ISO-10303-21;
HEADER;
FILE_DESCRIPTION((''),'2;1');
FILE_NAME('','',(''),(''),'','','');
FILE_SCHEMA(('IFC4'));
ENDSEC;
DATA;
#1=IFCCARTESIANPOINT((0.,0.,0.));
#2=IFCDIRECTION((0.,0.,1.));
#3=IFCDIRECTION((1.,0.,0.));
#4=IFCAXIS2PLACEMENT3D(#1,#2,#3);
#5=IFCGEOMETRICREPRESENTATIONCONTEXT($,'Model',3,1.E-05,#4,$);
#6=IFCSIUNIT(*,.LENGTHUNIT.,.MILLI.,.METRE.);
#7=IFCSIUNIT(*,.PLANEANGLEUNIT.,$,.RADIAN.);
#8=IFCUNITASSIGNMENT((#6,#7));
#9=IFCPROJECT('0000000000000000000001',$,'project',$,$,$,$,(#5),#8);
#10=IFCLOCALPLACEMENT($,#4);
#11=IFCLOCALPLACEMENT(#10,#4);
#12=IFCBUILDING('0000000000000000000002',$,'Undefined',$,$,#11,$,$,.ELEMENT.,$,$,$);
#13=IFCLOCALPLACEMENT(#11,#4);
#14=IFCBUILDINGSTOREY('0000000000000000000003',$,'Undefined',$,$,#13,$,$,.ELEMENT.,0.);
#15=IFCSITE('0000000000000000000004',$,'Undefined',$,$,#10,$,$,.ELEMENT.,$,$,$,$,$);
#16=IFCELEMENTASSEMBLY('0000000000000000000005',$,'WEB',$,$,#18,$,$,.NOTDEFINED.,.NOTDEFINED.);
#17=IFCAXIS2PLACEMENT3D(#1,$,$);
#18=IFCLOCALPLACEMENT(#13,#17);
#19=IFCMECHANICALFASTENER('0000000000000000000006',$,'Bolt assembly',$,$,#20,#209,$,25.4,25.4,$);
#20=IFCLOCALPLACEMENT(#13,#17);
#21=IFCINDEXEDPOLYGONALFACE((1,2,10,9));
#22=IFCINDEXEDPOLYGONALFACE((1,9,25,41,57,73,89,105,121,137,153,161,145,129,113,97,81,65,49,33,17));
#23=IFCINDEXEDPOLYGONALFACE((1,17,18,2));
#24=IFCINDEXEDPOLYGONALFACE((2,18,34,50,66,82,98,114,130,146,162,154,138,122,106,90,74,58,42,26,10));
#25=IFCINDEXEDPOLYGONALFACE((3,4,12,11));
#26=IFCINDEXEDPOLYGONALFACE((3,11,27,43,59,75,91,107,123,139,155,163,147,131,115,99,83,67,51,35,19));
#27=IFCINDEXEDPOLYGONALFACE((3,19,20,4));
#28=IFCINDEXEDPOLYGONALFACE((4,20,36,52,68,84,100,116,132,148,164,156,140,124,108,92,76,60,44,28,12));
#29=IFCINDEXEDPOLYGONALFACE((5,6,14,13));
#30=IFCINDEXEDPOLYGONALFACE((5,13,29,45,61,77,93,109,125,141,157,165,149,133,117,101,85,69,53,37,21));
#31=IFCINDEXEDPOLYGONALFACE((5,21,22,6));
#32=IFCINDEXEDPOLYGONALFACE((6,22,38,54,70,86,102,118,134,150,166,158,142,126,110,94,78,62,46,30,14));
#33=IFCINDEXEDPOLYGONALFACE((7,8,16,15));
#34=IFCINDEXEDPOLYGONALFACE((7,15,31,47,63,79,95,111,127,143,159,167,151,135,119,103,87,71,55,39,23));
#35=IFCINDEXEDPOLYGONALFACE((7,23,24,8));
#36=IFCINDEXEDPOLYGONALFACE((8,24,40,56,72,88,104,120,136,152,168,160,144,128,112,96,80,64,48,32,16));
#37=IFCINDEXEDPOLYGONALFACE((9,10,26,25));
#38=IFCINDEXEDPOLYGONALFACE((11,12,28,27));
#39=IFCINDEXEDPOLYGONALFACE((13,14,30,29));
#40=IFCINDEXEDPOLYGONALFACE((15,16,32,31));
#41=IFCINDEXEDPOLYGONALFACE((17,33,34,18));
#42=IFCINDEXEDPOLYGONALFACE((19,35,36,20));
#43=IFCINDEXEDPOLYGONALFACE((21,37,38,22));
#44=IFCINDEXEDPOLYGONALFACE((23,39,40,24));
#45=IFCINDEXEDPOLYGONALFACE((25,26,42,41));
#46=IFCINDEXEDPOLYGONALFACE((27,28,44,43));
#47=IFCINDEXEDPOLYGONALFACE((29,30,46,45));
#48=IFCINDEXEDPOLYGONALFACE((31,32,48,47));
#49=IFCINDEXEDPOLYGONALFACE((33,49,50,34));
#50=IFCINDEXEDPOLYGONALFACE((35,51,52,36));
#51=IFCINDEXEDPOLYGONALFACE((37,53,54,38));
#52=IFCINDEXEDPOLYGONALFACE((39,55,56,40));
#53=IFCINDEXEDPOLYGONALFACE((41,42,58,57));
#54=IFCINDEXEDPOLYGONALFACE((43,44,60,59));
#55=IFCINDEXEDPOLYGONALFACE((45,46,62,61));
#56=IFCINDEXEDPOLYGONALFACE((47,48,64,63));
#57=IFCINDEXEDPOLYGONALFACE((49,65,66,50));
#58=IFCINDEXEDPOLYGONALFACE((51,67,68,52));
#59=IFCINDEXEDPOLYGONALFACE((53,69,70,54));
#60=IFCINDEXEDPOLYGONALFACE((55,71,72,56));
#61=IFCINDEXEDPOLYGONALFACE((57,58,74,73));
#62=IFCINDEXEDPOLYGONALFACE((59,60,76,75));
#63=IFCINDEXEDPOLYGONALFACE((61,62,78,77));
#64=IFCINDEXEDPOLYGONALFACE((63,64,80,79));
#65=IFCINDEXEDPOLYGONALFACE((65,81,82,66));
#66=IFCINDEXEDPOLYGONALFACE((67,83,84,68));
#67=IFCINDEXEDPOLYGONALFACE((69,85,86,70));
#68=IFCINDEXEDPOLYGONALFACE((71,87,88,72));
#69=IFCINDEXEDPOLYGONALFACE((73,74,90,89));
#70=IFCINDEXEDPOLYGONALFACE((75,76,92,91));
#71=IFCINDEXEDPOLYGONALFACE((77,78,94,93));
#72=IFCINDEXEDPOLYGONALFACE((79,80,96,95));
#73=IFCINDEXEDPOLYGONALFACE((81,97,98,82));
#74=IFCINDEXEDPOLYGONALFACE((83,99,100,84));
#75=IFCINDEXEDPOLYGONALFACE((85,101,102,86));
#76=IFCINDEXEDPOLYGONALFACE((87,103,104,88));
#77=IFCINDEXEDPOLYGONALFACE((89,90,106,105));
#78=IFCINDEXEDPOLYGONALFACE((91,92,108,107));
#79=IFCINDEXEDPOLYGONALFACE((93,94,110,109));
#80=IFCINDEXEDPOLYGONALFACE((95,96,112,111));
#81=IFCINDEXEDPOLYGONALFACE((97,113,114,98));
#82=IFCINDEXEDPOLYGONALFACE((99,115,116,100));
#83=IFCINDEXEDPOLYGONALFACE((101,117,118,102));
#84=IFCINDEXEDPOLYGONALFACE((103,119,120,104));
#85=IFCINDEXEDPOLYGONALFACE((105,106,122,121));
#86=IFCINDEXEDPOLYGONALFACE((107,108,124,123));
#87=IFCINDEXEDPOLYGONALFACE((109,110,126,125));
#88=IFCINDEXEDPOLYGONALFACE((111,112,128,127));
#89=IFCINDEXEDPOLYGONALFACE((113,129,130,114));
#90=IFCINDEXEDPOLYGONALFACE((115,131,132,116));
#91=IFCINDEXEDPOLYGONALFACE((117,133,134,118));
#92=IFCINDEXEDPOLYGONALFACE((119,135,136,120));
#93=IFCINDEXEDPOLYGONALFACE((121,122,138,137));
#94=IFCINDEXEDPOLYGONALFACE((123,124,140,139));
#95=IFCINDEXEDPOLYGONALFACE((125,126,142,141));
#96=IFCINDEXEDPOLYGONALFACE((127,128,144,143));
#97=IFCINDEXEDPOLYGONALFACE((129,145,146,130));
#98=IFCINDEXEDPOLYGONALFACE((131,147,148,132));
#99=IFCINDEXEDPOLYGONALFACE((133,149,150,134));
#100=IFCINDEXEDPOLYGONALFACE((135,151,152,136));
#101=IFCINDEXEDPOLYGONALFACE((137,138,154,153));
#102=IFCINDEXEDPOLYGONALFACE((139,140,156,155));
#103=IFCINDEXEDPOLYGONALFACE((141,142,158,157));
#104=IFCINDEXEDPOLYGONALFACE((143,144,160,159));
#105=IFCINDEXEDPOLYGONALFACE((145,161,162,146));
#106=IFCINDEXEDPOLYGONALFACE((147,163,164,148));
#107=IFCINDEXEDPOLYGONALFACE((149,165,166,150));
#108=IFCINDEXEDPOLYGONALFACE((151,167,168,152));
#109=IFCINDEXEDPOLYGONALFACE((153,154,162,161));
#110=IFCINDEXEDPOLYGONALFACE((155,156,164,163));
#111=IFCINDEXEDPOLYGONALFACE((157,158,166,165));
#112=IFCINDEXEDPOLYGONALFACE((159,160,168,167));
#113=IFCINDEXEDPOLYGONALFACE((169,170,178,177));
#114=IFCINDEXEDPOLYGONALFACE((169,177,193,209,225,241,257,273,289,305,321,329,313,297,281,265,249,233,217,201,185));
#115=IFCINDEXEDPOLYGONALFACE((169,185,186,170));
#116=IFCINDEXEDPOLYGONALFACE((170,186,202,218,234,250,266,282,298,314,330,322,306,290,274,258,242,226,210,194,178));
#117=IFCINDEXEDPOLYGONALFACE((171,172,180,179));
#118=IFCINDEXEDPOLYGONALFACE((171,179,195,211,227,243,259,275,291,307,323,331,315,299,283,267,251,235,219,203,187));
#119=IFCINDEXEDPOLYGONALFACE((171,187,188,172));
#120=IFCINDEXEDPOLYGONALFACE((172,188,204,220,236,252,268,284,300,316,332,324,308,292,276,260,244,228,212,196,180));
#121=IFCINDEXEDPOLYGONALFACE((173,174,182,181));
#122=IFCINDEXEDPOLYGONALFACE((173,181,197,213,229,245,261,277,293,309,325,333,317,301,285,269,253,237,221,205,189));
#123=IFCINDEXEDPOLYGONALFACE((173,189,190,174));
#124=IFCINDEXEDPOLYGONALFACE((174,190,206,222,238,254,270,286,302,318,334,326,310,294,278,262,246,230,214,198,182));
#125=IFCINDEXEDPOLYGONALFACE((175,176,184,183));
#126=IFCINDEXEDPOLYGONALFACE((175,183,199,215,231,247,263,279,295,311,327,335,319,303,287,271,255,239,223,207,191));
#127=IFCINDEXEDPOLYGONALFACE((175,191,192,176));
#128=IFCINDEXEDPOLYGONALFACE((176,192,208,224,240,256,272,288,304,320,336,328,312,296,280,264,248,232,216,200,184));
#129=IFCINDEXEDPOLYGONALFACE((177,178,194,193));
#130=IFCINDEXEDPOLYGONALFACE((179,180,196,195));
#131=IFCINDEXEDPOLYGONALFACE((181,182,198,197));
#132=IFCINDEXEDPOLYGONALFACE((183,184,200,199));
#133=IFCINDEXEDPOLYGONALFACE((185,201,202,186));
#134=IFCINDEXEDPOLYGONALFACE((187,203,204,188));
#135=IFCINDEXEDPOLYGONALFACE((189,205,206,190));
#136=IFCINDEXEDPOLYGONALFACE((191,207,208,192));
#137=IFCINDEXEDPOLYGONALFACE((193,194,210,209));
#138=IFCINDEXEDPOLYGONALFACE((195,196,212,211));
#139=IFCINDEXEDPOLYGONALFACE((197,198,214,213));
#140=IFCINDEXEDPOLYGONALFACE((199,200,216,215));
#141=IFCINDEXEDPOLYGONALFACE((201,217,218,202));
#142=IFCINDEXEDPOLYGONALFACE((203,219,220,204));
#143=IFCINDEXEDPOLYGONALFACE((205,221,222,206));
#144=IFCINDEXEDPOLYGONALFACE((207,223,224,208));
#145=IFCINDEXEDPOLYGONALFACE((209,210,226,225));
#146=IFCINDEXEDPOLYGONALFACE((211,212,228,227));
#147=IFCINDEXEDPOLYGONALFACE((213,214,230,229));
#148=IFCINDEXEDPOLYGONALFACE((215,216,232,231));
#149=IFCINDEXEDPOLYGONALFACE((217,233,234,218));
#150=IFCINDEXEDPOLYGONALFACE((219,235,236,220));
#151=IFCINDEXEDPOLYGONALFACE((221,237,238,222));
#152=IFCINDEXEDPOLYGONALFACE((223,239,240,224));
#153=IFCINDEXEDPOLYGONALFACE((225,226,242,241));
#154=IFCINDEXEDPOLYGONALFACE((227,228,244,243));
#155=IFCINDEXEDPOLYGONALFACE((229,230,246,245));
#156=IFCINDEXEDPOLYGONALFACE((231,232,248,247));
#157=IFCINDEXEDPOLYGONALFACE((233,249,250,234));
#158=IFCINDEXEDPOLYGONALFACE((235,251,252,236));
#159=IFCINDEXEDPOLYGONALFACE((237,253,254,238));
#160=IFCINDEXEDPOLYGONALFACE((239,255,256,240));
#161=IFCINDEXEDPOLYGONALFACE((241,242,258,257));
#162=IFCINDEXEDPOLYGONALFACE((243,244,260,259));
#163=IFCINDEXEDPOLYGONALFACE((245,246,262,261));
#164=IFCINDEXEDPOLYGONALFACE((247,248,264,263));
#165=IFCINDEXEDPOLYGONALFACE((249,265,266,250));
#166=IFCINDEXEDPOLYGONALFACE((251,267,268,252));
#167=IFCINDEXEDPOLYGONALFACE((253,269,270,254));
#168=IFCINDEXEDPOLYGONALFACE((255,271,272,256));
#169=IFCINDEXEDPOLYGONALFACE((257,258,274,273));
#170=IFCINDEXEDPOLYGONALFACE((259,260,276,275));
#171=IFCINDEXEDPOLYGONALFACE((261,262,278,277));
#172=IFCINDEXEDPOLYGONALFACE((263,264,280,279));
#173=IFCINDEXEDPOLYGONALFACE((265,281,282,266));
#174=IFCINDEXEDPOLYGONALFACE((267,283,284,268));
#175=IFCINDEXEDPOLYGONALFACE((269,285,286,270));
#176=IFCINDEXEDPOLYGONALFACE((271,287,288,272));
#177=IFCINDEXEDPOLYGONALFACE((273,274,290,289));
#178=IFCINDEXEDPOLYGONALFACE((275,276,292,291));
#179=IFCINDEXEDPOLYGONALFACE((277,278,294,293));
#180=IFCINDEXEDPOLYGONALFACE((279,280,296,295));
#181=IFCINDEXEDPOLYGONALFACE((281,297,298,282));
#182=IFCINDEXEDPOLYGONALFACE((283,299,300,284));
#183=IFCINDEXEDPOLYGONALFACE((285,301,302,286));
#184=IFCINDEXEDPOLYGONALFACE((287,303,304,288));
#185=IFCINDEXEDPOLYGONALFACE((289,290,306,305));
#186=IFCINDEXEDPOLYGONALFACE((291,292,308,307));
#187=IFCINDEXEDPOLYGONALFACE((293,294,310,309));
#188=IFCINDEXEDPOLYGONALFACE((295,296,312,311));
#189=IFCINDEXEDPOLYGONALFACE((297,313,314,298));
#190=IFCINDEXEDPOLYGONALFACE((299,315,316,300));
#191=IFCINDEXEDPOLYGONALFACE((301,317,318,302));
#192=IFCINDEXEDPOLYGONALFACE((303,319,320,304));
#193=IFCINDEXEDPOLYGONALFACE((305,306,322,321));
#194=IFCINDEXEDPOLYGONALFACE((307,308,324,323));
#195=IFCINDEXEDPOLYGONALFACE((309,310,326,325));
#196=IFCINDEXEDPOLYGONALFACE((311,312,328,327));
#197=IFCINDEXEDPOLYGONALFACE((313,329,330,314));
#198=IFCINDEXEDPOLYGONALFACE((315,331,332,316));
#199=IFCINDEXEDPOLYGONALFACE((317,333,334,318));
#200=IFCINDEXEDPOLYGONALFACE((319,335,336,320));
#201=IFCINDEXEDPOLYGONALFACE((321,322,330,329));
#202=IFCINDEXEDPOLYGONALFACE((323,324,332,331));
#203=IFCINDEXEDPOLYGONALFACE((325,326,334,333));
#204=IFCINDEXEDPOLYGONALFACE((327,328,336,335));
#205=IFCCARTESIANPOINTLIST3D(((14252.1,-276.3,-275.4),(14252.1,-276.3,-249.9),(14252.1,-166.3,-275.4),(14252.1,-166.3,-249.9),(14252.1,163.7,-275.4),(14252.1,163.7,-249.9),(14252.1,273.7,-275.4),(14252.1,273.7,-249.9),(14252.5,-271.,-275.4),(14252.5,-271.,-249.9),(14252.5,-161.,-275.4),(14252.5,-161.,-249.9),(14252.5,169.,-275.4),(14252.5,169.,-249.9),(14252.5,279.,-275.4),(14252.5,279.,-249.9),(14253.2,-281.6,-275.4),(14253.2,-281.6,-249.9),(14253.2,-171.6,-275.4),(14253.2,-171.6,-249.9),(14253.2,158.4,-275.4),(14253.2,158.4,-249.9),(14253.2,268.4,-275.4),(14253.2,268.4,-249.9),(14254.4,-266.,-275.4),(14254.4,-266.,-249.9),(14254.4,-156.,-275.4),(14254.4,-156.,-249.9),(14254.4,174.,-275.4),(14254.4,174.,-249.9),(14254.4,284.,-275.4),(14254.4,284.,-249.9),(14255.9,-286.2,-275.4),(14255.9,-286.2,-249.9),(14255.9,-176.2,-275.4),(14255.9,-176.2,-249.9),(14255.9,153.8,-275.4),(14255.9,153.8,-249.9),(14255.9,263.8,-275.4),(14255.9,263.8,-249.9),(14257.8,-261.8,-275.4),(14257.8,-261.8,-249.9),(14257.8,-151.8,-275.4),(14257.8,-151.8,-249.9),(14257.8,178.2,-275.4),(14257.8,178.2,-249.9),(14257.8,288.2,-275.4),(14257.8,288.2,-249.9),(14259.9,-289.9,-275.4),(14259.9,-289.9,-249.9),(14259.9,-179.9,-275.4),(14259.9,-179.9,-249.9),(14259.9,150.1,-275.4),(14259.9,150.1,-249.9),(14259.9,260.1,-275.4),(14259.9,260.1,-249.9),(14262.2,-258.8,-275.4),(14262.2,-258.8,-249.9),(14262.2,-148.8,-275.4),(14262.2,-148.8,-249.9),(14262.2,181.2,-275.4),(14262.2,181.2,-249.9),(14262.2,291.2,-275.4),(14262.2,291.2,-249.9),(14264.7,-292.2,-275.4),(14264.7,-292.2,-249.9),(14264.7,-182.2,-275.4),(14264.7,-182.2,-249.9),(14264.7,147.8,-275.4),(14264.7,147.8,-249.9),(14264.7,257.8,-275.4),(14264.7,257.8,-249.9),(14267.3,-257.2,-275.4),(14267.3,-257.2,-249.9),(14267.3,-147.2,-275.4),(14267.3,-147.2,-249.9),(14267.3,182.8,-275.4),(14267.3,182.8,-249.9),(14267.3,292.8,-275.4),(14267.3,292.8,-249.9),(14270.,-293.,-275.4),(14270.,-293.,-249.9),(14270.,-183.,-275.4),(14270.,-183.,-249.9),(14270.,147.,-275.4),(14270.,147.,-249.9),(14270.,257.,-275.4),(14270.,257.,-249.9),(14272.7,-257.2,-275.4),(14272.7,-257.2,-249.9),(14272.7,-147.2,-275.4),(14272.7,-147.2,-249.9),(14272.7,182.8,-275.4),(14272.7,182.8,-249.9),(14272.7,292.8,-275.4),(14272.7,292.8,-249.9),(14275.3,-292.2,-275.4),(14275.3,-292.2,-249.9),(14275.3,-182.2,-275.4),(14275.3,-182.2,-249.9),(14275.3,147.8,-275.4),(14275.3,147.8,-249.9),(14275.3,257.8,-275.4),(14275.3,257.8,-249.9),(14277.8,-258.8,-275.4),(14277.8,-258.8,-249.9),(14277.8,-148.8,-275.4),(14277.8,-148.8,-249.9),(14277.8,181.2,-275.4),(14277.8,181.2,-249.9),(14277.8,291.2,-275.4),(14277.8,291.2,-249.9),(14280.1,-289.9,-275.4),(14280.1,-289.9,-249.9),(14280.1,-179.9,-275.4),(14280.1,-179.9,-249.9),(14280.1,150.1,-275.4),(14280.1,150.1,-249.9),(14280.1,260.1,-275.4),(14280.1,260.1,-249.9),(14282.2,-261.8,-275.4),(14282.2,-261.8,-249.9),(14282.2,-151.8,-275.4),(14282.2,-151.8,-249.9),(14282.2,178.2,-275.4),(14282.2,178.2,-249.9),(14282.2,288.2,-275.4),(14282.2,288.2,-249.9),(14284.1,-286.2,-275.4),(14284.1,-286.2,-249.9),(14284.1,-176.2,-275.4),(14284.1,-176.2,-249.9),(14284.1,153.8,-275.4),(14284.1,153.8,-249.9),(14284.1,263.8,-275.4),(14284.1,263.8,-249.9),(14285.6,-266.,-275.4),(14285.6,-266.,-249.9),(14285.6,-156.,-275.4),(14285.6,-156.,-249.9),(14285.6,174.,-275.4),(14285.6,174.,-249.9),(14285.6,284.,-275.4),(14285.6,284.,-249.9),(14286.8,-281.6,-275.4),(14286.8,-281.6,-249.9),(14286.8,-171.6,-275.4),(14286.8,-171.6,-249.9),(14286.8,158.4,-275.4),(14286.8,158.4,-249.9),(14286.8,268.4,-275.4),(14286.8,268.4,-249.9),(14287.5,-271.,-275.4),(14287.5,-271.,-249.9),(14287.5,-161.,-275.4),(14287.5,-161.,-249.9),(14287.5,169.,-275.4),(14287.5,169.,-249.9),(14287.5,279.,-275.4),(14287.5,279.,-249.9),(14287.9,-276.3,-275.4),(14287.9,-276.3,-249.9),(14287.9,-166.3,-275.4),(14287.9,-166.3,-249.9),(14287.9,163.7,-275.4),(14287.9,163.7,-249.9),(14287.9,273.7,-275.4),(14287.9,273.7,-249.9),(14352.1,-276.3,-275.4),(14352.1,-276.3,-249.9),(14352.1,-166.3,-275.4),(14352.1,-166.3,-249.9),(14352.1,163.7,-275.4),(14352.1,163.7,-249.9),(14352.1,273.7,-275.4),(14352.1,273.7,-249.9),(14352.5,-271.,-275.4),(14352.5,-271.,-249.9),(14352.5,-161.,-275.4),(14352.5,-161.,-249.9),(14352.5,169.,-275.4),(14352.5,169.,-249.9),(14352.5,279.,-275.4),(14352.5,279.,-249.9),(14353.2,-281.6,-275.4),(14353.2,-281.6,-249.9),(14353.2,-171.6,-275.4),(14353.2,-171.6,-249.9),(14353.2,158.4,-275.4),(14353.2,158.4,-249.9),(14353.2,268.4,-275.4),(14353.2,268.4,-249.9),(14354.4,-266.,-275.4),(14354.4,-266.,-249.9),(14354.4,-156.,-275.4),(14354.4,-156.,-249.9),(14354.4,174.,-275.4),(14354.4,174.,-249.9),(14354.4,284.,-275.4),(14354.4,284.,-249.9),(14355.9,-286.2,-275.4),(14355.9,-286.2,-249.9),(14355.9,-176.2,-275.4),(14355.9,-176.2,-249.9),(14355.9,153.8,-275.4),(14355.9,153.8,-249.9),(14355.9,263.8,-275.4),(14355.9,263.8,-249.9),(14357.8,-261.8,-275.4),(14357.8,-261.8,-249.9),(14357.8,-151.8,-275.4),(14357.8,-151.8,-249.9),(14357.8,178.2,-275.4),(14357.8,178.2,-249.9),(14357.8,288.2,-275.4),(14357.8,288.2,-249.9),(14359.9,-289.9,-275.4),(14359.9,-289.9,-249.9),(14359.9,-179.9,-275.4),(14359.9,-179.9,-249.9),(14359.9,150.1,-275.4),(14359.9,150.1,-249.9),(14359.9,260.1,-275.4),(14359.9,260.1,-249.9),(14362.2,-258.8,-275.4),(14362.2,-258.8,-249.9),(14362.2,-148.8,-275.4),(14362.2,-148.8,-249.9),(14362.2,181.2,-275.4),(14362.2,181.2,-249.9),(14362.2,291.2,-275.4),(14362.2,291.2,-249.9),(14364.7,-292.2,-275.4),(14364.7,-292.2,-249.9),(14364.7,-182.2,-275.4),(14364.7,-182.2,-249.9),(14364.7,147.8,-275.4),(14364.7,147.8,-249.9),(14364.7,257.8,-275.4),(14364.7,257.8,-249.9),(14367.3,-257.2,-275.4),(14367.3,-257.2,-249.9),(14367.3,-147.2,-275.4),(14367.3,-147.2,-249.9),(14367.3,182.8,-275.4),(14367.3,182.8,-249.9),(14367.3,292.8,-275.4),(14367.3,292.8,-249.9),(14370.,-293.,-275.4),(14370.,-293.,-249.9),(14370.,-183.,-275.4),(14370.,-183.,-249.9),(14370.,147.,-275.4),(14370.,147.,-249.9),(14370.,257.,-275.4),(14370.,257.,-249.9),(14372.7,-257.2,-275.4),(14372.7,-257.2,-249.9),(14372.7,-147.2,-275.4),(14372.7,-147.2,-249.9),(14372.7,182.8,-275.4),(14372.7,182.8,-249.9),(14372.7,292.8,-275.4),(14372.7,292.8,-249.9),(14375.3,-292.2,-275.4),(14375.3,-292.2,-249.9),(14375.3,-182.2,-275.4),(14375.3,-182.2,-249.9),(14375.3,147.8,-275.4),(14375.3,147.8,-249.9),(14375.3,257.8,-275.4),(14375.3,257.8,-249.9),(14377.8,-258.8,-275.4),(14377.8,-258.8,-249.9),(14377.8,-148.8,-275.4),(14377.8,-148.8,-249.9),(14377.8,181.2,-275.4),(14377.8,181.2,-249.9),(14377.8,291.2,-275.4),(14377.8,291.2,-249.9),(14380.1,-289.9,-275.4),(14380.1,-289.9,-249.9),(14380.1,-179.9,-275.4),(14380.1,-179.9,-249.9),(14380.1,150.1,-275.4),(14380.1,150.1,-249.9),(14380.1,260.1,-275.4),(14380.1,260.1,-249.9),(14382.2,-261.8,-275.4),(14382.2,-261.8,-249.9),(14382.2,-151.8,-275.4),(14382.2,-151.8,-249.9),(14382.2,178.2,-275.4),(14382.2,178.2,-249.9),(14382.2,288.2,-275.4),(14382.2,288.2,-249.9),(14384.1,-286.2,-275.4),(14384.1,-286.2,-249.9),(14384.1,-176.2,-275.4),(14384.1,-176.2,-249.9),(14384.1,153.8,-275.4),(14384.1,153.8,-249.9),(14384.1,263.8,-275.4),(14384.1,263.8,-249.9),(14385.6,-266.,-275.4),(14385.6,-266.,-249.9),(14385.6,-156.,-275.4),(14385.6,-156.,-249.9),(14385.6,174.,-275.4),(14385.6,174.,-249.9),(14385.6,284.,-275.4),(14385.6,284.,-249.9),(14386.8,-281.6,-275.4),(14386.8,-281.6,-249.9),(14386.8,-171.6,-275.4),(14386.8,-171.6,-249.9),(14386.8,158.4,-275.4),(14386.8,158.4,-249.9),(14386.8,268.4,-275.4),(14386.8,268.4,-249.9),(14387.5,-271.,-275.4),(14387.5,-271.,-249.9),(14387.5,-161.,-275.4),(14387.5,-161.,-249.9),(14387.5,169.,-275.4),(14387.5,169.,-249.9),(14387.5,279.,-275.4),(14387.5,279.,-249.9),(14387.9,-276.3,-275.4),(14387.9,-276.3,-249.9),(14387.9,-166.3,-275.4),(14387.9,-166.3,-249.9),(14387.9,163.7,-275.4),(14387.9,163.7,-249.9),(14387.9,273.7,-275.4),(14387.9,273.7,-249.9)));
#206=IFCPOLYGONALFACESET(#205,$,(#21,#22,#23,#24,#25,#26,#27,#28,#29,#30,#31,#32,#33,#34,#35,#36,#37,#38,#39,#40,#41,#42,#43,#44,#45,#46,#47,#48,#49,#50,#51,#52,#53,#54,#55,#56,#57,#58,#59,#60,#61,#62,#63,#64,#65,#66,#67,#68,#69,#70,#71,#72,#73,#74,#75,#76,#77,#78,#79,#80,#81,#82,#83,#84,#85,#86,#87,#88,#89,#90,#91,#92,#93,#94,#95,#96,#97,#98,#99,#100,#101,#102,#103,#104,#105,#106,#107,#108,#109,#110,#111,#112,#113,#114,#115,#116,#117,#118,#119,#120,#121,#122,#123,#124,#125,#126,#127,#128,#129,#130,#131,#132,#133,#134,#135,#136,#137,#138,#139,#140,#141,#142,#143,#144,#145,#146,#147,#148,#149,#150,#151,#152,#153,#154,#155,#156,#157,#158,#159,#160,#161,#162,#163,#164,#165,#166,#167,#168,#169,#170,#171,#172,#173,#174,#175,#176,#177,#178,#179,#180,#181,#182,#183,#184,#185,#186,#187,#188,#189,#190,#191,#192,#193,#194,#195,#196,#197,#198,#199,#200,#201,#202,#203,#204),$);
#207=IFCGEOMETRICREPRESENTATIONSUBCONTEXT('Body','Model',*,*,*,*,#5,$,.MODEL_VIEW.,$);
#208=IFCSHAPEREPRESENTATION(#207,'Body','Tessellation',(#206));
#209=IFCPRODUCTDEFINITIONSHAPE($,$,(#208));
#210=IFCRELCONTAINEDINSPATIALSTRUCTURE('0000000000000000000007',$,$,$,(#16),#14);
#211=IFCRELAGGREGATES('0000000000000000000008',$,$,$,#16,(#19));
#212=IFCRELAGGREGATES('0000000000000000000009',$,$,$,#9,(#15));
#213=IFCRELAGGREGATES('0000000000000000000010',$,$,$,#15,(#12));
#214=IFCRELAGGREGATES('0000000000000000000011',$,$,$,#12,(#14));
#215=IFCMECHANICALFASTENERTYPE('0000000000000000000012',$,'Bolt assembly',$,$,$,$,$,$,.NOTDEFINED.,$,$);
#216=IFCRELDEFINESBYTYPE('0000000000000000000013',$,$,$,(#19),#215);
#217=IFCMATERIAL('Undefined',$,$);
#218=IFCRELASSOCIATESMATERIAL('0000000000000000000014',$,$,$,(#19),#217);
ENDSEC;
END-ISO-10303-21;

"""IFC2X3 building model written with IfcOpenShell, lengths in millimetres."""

from ifc_helpers import new_model, si_unit, frame, origin_with_axes, origin_2d_with_axis, place, context, subcontext, project, spatial, circle, extrude, source, transform, mapped, material, type_object, element, aggregate, save


model = new_model("IFC2X3")

# Units and contexts
model_context = context("Model", 3, precision=1e-05, world=origin_with_axes())
body_context = subcontext(model_context, "Body", "Model", "MODEL_VIEW")
ifc_project = project(units=[si_unit("LENGTHUNIT", "METRE", prefix="MILLI"), si_unit("PLANEANGLEUNIT", "RADIAN")], contexts=[model_context])

# Site, building, storey
site_placement = place(None, origin_with_axes())
site = spatial("IfcSite", under=ifc_project, at=site_placement, Name="Undefined", CompositionType="ELEMENT")
building_placement = place(site_placement, origin_with_axes())
building = spatial("IfcBuilding", under=site, at=building_placement, Name="Undefined", CompositionType="ELEMENT")
storey_placement = place(building_placement, origin_with_axes())
storey = spatial("IfcBuildingStorey", under=building, at=storey_placement, Name="Undefined", CompositionType="ELEMENT", Elevation=0.0)

# Element assembly
assembly_1_placement = place(storey_placement, origin_with_axes())
assembly_1 = element("IfcElementAssembly", 1, at=assembly_1_placement, inside=storey, Name="WEB", AssemblyPlace="NOTDEFINED", PredefinedType="NOTDEFINED")
ifc_material_1 = material(Name="Undefined")
mechanical_fastener_type = type_object("IfcMechanicalFastenerType", Name="Bolt assembly")

# Mechanical fastener
shared_shape_1 = source(origin_with_axes(), body_context, "Body", "SweptSolid", [
    extrude(circle(Radius=18.0, at=origin_2d_with_axis()), frame((0.0, -8.0, 0.0), z_axis=(0.0, 1.0, 0.0), x_axis=(1.0, 0.0, 0.0)), (0.0, 0.0, 1.0), 25.5),
])
mechanical_fastener_1_placement = place(assembly_1_placement, frame((14320.0, 275.0, -267.4), z_axis=(-1.0, 0.0, 0.0), x_axis=(0.0, -1.0, 0.0)))
mechanical_fastener_1 = element("IfcMechanicalFastener", 2, at=mechanical_fastener_1_placement, type_object=mechanical_fastener_type, material=ifc_material_1, Name="Bolt assembly", NominalDiameter=25.4, NominalLength=25.4, context=body_context, shape_type="MappedRepresentation", body=[
    mapped(shared_shape_1, transform((0.0, 0.0, -50.0))),
    mapped(shared_shape_1, transform((110.0, 0.0, -50.0))),
    mapped(shared_shape_1, transform((440.0, 0.0, -50.0))),
    mapped(shared_shape_1, transform((550.0, 0.0, -50.0))),
    mapped(shared_shape_1, transform((0.0, 0.0, 50.0))),
    mapped(shared_shape_1, transform((110.0, 0.0, 50.0))),
    mapped(shared_shape_1, transform((440.0, 0.0, 50.0))),
    mapped(shared_shape_1, transform((550.0, 0.0, 50.0))),
])
aggregate(assembly_1, [mechanical_fastener_1])

save(model, "model.ifc")
